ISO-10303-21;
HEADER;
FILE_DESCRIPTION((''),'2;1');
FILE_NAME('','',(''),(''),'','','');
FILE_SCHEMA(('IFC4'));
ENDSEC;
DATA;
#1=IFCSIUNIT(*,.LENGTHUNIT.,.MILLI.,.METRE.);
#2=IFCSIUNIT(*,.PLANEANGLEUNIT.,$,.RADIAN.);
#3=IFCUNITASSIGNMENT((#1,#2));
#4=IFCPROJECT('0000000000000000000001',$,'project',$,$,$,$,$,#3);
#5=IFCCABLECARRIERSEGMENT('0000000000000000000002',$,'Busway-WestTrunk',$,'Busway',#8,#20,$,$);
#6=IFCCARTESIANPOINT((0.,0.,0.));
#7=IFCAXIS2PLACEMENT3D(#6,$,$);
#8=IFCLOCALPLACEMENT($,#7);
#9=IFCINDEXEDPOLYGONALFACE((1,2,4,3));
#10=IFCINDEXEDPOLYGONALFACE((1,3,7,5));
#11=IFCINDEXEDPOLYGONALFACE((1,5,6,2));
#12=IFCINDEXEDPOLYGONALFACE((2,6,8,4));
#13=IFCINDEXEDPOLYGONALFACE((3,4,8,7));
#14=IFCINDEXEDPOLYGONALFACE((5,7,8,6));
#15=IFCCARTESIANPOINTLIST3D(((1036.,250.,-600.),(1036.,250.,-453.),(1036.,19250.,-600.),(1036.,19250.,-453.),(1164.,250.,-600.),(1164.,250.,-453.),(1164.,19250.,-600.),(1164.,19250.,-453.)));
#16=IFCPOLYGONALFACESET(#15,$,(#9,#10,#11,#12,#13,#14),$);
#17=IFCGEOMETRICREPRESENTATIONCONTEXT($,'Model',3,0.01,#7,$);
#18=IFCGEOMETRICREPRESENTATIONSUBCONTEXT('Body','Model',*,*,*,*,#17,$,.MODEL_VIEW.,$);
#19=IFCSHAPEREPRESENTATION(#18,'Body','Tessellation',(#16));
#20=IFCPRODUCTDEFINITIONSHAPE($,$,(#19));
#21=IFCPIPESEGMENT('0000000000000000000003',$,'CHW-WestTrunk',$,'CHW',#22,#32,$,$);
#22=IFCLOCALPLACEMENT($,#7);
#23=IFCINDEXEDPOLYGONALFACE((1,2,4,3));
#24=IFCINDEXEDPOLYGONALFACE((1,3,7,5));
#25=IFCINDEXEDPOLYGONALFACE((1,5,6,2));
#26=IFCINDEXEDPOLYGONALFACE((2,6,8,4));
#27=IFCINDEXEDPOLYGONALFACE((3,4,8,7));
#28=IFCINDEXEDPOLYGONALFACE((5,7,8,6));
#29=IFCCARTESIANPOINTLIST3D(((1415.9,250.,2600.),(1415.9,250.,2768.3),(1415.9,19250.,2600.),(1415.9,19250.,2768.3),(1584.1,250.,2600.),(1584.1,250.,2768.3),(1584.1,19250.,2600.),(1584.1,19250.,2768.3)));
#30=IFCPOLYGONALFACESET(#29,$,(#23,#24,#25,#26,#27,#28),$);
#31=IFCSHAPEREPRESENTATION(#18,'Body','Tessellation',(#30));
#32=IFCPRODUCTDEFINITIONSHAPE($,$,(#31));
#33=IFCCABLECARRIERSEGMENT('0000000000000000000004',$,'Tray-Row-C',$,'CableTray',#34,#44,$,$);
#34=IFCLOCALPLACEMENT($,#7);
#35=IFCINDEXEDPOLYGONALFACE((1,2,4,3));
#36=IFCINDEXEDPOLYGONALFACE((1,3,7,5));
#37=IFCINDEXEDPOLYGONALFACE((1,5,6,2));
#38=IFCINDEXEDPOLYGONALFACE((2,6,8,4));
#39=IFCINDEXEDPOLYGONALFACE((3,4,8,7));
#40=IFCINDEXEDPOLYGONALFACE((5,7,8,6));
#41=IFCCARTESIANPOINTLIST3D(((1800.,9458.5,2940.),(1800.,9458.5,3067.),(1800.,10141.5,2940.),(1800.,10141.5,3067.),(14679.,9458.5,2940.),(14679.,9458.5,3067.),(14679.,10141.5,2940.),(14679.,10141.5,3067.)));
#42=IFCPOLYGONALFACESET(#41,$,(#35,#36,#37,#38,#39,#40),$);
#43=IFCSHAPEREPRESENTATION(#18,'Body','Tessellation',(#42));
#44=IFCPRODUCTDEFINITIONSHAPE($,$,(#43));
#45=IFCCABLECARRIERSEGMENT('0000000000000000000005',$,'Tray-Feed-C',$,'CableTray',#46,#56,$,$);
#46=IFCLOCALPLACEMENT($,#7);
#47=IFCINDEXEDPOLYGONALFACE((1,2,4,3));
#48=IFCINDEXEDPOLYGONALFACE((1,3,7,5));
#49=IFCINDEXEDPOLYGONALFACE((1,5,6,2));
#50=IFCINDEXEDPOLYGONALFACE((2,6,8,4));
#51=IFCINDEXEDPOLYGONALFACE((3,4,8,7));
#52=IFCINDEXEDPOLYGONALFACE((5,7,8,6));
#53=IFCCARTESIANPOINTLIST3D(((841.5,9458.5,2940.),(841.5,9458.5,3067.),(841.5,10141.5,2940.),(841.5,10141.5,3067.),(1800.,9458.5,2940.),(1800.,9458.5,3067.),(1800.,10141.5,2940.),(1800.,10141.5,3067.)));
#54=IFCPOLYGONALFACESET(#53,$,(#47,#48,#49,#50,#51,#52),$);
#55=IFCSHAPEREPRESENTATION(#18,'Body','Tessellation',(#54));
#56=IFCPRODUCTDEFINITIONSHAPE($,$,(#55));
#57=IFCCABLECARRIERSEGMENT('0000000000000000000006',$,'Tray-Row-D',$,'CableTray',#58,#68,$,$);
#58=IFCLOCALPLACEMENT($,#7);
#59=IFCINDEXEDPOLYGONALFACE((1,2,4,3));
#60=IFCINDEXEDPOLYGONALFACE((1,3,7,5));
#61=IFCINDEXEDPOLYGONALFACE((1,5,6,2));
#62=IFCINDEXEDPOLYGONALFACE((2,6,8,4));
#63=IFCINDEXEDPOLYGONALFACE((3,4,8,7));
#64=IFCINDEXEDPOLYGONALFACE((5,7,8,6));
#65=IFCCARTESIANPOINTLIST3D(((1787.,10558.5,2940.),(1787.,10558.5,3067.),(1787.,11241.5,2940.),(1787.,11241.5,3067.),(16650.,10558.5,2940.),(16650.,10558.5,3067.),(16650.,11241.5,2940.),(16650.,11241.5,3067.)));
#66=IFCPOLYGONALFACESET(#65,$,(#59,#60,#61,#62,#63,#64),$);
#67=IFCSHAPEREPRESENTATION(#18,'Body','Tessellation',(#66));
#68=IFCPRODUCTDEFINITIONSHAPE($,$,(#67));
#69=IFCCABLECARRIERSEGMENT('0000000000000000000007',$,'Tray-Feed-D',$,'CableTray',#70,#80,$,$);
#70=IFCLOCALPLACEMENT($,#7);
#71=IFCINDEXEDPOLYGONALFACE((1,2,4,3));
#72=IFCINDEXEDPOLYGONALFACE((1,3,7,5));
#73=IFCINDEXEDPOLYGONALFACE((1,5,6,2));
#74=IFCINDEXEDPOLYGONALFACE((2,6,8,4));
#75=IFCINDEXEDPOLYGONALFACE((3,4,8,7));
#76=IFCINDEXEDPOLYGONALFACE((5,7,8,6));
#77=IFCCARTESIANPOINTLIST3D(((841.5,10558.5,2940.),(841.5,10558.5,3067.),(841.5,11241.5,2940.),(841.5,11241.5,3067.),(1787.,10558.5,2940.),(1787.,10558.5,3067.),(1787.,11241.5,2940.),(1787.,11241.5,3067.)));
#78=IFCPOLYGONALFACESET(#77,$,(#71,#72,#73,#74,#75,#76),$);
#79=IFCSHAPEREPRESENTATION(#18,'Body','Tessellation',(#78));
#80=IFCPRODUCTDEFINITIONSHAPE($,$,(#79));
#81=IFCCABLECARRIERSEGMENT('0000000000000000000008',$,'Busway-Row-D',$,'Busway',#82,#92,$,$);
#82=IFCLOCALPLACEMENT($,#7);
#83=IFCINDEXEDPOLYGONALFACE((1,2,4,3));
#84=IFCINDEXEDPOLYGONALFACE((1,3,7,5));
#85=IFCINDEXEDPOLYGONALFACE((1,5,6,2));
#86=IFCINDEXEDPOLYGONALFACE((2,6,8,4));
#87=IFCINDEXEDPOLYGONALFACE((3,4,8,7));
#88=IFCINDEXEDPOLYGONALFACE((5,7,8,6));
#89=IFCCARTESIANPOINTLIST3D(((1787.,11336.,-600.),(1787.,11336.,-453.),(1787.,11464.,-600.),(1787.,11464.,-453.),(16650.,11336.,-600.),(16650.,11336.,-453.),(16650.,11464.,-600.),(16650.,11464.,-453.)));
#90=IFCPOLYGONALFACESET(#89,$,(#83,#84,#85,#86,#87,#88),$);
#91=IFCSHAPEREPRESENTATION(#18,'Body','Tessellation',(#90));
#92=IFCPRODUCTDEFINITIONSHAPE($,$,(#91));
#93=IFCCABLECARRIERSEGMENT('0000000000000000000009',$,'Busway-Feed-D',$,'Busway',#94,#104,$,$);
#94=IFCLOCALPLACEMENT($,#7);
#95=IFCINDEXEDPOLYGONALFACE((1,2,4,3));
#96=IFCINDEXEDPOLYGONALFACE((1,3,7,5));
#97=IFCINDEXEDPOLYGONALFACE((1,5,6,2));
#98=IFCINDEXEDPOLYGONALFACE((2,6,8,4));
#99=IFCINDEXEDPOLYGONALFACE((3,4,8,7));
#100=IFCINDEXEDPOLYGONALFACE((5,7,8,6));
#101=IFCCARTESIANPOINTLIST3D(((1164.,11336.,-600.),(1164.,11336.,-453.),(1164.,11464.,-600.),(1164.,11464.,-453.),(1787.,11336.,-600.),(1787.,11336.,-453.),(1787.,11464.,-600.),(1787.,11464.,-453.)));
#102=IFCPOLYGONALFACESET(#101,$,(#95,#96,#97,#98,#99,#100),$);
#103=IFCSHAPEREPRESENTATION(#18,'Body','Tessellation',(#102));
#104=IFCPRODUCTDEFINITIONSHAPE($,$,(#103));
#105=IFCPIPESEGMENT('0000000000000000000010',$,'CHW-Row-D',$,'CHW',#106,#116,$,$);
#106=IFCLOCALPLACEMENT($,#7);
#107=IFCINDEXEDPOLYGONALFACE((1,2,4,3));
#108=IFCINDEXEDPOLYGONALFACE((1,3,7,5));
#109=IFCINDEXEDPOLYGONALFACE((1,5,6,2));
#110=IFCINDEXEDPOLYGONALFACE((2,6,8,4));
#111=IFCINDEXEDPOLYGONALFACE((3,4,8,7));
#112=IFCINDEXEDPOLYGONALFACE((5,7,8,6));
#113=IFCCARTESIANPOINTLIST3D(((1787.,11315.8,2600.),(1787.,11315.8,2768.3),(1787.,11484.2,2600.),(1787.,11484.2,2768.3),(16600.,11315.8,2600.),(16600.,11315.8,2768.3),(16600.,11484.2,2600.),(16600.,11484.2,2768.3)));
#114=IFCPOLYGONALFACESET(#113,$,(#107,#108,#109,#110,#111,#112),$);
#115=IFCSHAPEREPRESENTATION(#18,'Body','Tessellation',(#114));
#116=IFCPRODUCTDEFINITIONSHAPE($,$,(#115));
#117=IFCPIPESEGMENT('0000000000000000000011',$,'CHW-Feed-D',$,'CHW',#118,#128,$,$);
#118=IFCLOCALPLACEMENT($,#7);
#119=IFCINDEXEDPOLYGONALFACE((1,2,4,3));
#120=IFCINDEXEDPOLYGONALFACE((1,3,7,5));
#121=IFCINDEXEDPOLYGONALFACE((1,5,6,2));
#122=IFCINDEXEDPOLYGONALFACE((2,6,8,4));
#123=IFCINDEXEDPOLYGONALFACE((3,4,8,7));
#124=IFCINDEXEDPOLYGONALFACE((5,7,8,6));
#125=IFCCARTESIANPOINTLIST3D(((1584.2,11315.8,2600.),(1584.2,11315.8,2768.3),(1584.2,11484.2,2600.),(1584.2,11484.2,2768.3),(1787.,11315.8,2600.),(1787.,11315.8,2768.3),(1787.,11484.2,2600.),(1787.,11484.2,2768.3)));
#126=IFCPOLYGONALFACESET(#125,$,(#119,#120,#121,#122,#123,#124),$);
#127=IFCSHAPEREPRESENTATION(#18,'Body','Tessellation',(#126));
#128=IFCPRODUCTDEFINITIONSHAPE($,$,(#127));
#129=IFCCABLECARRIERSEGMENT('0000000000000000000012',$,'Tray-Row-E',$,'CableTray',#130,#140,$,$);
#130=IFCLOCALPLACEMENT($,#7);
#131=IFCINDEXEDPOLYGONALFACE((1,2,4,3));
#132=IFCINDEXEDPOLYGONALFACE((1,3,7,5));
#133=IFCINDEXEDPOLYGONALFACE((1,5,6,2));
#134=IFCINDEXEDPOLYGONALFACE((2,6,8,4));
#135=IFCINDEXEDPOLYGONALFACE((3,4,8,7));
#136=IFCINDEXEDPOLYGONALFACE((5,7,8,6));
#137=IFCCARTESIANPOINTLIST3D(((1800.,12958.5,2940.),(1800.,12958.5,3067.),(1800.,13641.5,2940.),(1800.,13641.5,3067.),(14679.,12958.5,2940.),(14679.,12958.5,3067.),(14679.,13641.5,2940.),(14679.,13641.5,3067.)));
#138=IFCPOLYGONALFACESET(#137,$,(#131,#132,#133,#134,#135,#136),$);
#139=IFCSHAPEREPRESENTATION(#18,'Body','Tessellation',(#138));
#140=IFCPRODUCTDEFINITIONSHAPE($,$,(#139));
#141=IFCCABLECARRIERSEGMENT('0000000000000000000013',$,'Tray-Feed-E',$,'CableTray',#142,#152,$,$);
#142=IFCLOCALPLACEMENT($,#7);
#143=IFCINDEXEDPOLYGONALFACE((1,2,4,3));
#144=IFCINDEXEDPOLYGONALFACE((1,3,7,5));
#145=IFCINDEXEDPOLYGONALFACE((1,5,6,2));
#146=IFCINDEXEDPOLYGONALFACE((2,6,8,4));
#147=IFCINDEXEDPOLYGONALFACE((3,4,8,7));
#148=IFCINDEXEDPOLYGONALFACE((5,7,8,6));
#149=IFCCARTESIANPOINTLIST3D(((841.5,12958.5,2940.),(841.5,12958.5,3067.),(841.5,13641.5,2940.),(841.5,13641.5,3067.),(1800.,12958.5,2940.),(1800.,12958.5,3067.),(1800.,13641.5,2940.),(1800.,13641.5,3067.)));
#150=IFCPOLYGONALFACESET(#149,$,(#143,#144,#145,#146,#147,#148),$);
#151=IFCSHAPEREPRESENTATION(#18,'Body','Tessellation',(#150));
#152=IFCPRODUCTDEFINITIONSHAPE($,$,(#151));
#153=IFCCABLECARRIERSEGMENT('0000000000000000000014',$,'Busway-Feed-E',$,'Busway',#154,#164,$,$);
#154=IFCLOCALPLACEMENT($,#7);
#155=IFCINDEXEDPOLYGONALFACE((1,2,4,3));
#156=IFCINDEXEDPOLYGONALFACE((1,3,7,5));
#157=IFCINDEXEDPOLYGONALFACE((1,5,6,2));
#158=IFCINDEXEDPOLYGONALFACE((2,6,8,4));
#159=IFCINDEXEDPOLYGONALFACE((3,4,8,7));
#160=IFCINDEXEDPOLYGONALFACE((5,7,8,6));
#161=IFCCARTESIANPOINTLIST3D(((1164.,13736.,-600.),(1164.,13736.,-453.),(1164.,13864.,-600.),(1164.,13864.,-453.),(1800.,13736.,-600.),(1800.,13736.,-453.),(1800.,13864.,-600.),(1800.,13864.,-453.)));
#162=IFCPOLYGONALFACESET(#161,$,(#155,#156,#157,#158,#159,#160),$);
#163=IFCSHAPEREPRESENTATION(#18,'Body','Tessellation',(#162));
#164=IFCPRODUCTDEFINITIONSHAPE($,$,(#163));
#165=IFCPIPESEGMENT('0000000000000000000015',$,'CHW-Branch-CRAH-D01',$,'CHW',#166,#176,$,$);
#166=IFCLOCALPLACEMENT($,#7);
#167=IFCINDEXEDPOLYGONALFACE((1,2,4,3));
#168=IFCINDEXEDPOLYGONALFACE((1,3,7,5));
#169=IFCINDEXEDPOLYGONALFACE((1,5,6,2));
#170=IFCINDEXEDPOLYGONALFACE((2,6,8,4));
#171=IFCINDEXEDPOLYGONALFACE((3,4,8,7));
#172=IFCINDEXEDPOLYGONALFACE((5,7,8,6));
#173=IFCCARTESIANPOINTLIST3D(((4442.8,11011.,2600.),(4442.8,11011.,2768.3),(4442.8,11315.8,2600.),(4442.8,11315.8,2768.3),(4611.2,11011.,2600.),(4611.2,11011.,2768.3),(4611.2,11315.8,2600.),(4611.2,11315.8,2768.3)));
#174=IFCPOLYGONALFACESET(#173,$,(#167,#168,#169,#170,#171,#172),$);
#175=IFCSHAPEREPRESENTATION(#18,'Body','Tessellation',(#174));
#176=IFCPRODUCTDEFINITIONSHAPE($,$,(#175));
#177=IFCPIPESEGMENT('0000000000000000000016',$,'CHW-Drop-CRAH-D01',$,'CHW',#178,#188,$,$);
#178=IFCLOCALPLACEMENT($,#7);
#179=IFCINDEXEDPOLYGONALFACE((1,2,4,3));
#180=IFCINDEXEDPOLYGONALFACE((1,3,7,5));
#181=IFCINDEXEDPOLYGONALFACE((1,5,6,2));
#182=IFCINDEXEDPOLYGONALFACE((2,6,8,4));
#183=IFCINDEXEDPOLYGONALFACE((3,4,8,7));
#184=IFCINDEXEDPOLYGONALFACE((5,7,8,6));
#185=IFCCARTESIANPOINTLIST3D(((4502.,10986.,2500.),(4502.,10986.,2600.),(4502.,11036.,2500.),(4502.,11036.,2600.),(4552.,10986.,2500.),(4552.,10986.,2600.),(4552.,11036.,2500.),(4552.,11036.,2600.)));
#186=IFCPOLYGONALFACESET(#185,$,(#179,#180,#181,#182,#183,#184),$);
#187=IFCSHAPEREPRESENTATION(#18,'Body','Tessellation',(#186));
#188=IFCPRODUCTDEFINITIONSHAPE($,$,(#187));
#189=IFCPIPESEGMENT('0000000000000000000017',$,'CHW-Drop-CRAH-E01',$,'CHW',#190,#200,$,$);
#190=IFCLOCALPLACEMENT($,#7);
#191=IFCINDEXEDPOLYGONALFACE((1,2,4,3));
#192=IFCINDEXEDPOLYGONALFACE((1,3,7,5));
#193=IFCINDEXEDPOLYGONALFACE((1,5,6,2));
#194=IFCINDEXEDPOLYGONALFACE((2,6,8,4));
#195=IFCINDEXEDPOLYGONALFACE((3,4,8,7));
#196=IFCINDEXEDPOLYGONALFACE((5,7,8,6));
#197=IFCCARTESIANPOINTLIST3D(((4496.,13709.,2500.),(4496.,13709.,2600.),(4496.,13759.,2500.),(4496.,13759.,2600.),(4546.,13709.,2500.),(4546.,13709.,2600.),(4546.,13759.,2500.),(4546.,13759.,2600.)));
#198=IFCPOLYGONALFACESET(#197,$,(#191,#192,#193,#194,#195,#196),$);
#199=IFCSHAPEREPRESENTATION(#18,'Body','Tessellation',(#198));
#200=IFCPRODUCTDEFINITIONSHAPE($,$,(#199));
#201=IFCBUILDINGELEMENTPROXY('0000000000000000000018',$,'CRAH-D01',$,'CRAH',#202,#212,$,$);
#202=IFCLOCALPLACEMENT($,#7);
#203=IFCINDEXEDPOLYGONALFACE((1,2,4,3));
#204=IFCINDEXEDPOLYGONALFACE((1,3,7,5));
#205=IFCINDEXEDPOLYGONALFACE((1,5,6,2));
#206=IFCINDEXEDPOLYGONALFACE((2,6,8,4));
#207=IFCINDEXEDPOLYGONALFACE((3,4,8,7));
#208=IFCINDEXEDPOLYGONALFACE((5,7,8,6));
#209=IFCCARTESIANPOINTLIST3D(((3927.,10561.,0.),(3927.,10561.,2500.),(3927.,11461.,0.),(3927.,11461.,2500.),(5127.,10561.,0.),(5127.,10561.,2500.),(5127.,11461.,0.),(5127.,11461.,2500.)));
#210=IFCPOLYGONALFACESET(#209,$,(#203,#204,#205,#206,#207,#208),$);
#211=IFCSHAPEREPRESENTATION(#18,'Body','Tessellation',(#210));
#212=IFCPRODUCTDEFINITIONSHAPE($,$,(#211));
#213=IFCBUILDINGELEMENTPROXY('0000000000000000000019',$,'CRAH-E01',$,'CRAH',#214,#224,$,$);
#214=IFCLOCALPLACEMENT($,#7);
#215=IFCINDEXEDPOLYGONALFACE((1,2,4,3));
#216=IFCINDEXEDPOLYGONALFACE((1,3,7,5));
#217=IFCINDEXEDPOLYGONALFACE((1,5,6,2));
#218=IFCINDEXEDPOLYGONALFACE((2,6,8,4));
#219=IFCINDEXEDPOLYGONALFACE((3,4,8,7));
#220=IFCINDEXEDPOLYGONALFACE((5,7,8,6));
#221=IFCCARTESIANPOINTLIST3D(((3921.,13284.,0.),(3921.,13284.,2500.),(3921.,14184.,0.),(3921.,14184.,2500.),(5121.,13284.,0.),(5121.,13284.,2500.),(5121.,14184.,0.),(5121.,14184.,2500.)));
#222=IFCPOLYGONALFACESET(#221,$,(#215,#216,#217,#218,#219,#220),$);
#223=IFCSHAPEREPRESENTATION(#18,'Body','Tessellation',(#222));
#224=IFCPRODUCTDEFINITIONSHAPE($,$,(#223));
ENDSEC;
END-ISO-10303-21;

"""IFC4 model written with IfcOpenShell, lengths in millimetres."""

from ifc_helpers import new_model, si_unit, frame, origin, place, context, subcontext, project, rectangle, extrude, element, save


model = new_model("IFC4")

# Units and contexts
model_context = context("Model", 3, precision=0.01, world=origin())
body_context = subcontext(model_context, "Body", "Model", "MODEL_VIEW")
ifc_project = project(units=[si_unit("LENGTHUNIT", "METRE", prefix="MILLI"), si_unit("PLANEANGLEUNIT", "RADIAN")])

# Cable carrier segment
placement = place(None, origin())
cable_carrier_segment_1_placement = place(placement, frame((1100.0, 9750.0, -600.0)))
element("IfcCableCarrierSegment", 1, at=cable_carrier_segment_1_placement, Name="Busway-WestTrunk", ObjectType="Busway", context=body_context, shape_type="SweptSolid", body=[
    extrude(rectangle(XDim=128.0, YDim=19000.0), origin(), (0.0, 0.0, 1.0), 147.0),
])

# Pipe segment
pipe_segment_1_placement = place(placement, frame((1500.0, 9750.0, 2600.0)))
element("IfcPipeSegment", 2, at=pipe_segment_1_placement, Name="CHW-WestTrunk", ObjectType="CHW", context=body_context, shape_type="SweptSolid", body=[
    extrude(rectangle(XDim=168.3, YDim=19000.0), origin(), (0.0, 0.0, 1.0), 168.3),
])

# Cable carrier segments
cable_carrier_segment_2_placement = place(placement, frame((8239.5, 9800.0, 2940.0)))
element("IfcCableCarrierSegment", 3, at=cable_carrier_segment_2_placement, Name="Tray-Row-C", ObjectType="CableTray", context=body_context, shape_type="SweptSolid", body=[
    extrude(rectangle(XDim=12879.0, YDim=683.0), origin(), (0.0, 0.0, 1.0), 127.0),
])
cable_carrier_segment_3_placement = place(placement, frame((1320.8, 9800.0, 2940.0)))
element("IfcCableCarrierSegment", 4, at=cable_carrier_segment_3_placement, Name="Tray-Feed-C", ObjectType="CableTray", context=body_context, shape_type="SweptSolid", body=[
    extrude(rectangle(XDim=958.5, YDim=683.0), origin(), (0.0, 0.0, 1.0), 127.0),
])
cable_carrier_segment_4_placement = place(placement, frame((9218.5, 10900.0, 2940.0)))
element("IfcCableCarrierSegment", 5, at=cable_carrier_segment_4_placement, Name="Tray-Row-D", ObjectType="CableTray", context=body_context, shape_type="SweptSolid", body=[
    extrude(rectangle(XDim=14863.0, YDim=683.0), origin(), (0.0, 0.0, 1.0), 127.0),
])
cable_carrier_segment_5_placement = place(placement, frame((1314.2, 10900.0, 2940.0)))
element("IfcCableCarrierSegment", 6, at=cable_carrier_segment_5_placement, Name="Tray-Feed-D", ObjectType="CableTray", context=body_context, shape_type="SweptSolid", body=[
    extrude(rectangle(XDim=945.5, YDim=683.0), origin(), (0.0, 0.0, 1.0), 127.0),
])
cable_carrier_segment_6_placement = place(placement, frame((9218.5, 11400.0, -600.0)))
element("IfcCableCarrierSegment", 7, at=cable_carrier_segment_6_placement, Name="Busway-Row-D", ObjectType="Busway", context=body_context, shape_type="SweptSolid", body=[
    extrude(rectangle(XDim=14863.0, YDim=128.0), origin(), (0.0, 0.0, 1.0), 147.0),
])
cable_carrier_segment_7_placement = place(placement, frame((1475.5, 11400.0, -600.0)))
element("IfcCableCarrierSegment", 8, at=cable_carrier_segment_7_placement, Name="Busway-Feed-D", ObjectType="Busway", context=body_context, shape_type="SweptSolid", body=[
    extrude(rectangle(XDim=623.0, YDim=128.0), origin(), (0.0, 0.0, 1.0), 147.0),
])

# Pipe segments
pipe_segment_2_placement = place(placement, frame((9193.5, 11400.0, 2600.0)))
element("IfcPipeSegment", 9, at=pipe_segment_2_placement, Name="CHW-Row-D", ObjectType="CHW", context=body_context, shape_type="SweptSolid", body=[
    extrude(rectangle(XDim=14813.0, YDim=168.3), origin(), (0.0, 0.0, 1.0), 168.3),
])
pipe_segment_3_placement = place(placement, frame((1685.6, 11400.0, 2600.0)))
element("IfcPipeSegment", 10, at=pipe_segment_3_placement, Name="CHW-Feed-D", ObjectType="CHW", context=body_context, shape_type="SweptSolid", body=[
    extrude(rectangle(XDim=202.8, YDim=168.3), origin(), (0.0, 0.0, 1.0), 168.3),
])

# Cable carrier segments
cable_carrier_segment_8_placement = place(placement, frame((8239.5, 13300.0, 2940.0)))
element("IfcCableCarrierSegment", 11, at=cable_carrier_segment_8_placement, Name="Tray-Row-E", ObjectType="CableTray", context=body_context, shape_type="SweptSolid", body=[
    extrude(rectangle(XDim=12879.0, YDim=683.0), origin(), (0.0, 0.0, 1.0), 127.0),
])
cable_carrier_segment_9_placement = place(placement, frame((1320.8, 13300.0, 2940.0)))
element("IfcCableCarrierSegment", 12, at=cable_carrier_segment_9_placement, Name="Tray-Feed-E", ObjectType="CableTray", context=body_context, shape_type="SweptSolid", body=[
    extrude(rectangle(XDim=958.5, YDim=683.0), origin(), (0.0, 0.0, 1.0), 127.0),
])
cable_carrier_segment_10_placement = place(placement, frame((1482.0, 13800.0, -600.0)))
element("IfcCableCarrierSegment", 13, at=cable_carrier_segment_10_placement, Name="Busway-Feed-E", ObjectType="Busway", context=body_context, shape_type="SweptSolid", body=[
    extrude(rectangle(XDim=636.0, YDim=128.0), origin(), (0.0, 0.0, 1.0), 147.0),
])

# Pipe segments
pipe_segment_4_placement = place(placement, frame((4527.0, 11163.4, 2600.0)))
element("IfcPipeSegment", 14, at=pipe_segment_4_placement, Name="CHW-Branch-CRAH-D01", ObjectType="CHW", context=body_context, shape_type="SweptSolid", body=[
    extrude(rectangle(XDim=168.3, YDim=304.9), origin(), (0.0, 0.0, 1.0), 168.3),
])
for number, where, name in (
    (15, (4527.0, 11011.0, 2500.0), "CHW-Drop-CRAH-D01"),
    (16, (4521.0, 13734.0, 2500.0), "CHW-Drop-CRAH-E01"),
):
    element("IfcPipeSegment", number, at=place(placement, frame(where)), Name=name, ObjectType="CHW", context=body_context, shape_type="SweptSolid", body=[
        extrude(rectangle(XDim=50.0, YDim=50.0), origin(), (0.0, 0.0, 1.0), 100.0),
    ])

# Building element proxies
for number, where, name in (
    (17, (4527.0, 11011.0, 0.0), "CRAH-D01"),
    (18, (4521.0, 13734.0, 0.0), "CRAH-E01"),
):
    element("IfcBuildingElementProxy", number, at=place(placement, frame(where)), Name=name, ObjectType="CRAH", context=body_context, shape_type="SweptSolid", body=[
        extrude(rectangle(XDim=1200.0, YDim=900.0), origin(), (0.0, 0.0, 1.0), 2500.0),
    ])

save(model, "model.ifc")
